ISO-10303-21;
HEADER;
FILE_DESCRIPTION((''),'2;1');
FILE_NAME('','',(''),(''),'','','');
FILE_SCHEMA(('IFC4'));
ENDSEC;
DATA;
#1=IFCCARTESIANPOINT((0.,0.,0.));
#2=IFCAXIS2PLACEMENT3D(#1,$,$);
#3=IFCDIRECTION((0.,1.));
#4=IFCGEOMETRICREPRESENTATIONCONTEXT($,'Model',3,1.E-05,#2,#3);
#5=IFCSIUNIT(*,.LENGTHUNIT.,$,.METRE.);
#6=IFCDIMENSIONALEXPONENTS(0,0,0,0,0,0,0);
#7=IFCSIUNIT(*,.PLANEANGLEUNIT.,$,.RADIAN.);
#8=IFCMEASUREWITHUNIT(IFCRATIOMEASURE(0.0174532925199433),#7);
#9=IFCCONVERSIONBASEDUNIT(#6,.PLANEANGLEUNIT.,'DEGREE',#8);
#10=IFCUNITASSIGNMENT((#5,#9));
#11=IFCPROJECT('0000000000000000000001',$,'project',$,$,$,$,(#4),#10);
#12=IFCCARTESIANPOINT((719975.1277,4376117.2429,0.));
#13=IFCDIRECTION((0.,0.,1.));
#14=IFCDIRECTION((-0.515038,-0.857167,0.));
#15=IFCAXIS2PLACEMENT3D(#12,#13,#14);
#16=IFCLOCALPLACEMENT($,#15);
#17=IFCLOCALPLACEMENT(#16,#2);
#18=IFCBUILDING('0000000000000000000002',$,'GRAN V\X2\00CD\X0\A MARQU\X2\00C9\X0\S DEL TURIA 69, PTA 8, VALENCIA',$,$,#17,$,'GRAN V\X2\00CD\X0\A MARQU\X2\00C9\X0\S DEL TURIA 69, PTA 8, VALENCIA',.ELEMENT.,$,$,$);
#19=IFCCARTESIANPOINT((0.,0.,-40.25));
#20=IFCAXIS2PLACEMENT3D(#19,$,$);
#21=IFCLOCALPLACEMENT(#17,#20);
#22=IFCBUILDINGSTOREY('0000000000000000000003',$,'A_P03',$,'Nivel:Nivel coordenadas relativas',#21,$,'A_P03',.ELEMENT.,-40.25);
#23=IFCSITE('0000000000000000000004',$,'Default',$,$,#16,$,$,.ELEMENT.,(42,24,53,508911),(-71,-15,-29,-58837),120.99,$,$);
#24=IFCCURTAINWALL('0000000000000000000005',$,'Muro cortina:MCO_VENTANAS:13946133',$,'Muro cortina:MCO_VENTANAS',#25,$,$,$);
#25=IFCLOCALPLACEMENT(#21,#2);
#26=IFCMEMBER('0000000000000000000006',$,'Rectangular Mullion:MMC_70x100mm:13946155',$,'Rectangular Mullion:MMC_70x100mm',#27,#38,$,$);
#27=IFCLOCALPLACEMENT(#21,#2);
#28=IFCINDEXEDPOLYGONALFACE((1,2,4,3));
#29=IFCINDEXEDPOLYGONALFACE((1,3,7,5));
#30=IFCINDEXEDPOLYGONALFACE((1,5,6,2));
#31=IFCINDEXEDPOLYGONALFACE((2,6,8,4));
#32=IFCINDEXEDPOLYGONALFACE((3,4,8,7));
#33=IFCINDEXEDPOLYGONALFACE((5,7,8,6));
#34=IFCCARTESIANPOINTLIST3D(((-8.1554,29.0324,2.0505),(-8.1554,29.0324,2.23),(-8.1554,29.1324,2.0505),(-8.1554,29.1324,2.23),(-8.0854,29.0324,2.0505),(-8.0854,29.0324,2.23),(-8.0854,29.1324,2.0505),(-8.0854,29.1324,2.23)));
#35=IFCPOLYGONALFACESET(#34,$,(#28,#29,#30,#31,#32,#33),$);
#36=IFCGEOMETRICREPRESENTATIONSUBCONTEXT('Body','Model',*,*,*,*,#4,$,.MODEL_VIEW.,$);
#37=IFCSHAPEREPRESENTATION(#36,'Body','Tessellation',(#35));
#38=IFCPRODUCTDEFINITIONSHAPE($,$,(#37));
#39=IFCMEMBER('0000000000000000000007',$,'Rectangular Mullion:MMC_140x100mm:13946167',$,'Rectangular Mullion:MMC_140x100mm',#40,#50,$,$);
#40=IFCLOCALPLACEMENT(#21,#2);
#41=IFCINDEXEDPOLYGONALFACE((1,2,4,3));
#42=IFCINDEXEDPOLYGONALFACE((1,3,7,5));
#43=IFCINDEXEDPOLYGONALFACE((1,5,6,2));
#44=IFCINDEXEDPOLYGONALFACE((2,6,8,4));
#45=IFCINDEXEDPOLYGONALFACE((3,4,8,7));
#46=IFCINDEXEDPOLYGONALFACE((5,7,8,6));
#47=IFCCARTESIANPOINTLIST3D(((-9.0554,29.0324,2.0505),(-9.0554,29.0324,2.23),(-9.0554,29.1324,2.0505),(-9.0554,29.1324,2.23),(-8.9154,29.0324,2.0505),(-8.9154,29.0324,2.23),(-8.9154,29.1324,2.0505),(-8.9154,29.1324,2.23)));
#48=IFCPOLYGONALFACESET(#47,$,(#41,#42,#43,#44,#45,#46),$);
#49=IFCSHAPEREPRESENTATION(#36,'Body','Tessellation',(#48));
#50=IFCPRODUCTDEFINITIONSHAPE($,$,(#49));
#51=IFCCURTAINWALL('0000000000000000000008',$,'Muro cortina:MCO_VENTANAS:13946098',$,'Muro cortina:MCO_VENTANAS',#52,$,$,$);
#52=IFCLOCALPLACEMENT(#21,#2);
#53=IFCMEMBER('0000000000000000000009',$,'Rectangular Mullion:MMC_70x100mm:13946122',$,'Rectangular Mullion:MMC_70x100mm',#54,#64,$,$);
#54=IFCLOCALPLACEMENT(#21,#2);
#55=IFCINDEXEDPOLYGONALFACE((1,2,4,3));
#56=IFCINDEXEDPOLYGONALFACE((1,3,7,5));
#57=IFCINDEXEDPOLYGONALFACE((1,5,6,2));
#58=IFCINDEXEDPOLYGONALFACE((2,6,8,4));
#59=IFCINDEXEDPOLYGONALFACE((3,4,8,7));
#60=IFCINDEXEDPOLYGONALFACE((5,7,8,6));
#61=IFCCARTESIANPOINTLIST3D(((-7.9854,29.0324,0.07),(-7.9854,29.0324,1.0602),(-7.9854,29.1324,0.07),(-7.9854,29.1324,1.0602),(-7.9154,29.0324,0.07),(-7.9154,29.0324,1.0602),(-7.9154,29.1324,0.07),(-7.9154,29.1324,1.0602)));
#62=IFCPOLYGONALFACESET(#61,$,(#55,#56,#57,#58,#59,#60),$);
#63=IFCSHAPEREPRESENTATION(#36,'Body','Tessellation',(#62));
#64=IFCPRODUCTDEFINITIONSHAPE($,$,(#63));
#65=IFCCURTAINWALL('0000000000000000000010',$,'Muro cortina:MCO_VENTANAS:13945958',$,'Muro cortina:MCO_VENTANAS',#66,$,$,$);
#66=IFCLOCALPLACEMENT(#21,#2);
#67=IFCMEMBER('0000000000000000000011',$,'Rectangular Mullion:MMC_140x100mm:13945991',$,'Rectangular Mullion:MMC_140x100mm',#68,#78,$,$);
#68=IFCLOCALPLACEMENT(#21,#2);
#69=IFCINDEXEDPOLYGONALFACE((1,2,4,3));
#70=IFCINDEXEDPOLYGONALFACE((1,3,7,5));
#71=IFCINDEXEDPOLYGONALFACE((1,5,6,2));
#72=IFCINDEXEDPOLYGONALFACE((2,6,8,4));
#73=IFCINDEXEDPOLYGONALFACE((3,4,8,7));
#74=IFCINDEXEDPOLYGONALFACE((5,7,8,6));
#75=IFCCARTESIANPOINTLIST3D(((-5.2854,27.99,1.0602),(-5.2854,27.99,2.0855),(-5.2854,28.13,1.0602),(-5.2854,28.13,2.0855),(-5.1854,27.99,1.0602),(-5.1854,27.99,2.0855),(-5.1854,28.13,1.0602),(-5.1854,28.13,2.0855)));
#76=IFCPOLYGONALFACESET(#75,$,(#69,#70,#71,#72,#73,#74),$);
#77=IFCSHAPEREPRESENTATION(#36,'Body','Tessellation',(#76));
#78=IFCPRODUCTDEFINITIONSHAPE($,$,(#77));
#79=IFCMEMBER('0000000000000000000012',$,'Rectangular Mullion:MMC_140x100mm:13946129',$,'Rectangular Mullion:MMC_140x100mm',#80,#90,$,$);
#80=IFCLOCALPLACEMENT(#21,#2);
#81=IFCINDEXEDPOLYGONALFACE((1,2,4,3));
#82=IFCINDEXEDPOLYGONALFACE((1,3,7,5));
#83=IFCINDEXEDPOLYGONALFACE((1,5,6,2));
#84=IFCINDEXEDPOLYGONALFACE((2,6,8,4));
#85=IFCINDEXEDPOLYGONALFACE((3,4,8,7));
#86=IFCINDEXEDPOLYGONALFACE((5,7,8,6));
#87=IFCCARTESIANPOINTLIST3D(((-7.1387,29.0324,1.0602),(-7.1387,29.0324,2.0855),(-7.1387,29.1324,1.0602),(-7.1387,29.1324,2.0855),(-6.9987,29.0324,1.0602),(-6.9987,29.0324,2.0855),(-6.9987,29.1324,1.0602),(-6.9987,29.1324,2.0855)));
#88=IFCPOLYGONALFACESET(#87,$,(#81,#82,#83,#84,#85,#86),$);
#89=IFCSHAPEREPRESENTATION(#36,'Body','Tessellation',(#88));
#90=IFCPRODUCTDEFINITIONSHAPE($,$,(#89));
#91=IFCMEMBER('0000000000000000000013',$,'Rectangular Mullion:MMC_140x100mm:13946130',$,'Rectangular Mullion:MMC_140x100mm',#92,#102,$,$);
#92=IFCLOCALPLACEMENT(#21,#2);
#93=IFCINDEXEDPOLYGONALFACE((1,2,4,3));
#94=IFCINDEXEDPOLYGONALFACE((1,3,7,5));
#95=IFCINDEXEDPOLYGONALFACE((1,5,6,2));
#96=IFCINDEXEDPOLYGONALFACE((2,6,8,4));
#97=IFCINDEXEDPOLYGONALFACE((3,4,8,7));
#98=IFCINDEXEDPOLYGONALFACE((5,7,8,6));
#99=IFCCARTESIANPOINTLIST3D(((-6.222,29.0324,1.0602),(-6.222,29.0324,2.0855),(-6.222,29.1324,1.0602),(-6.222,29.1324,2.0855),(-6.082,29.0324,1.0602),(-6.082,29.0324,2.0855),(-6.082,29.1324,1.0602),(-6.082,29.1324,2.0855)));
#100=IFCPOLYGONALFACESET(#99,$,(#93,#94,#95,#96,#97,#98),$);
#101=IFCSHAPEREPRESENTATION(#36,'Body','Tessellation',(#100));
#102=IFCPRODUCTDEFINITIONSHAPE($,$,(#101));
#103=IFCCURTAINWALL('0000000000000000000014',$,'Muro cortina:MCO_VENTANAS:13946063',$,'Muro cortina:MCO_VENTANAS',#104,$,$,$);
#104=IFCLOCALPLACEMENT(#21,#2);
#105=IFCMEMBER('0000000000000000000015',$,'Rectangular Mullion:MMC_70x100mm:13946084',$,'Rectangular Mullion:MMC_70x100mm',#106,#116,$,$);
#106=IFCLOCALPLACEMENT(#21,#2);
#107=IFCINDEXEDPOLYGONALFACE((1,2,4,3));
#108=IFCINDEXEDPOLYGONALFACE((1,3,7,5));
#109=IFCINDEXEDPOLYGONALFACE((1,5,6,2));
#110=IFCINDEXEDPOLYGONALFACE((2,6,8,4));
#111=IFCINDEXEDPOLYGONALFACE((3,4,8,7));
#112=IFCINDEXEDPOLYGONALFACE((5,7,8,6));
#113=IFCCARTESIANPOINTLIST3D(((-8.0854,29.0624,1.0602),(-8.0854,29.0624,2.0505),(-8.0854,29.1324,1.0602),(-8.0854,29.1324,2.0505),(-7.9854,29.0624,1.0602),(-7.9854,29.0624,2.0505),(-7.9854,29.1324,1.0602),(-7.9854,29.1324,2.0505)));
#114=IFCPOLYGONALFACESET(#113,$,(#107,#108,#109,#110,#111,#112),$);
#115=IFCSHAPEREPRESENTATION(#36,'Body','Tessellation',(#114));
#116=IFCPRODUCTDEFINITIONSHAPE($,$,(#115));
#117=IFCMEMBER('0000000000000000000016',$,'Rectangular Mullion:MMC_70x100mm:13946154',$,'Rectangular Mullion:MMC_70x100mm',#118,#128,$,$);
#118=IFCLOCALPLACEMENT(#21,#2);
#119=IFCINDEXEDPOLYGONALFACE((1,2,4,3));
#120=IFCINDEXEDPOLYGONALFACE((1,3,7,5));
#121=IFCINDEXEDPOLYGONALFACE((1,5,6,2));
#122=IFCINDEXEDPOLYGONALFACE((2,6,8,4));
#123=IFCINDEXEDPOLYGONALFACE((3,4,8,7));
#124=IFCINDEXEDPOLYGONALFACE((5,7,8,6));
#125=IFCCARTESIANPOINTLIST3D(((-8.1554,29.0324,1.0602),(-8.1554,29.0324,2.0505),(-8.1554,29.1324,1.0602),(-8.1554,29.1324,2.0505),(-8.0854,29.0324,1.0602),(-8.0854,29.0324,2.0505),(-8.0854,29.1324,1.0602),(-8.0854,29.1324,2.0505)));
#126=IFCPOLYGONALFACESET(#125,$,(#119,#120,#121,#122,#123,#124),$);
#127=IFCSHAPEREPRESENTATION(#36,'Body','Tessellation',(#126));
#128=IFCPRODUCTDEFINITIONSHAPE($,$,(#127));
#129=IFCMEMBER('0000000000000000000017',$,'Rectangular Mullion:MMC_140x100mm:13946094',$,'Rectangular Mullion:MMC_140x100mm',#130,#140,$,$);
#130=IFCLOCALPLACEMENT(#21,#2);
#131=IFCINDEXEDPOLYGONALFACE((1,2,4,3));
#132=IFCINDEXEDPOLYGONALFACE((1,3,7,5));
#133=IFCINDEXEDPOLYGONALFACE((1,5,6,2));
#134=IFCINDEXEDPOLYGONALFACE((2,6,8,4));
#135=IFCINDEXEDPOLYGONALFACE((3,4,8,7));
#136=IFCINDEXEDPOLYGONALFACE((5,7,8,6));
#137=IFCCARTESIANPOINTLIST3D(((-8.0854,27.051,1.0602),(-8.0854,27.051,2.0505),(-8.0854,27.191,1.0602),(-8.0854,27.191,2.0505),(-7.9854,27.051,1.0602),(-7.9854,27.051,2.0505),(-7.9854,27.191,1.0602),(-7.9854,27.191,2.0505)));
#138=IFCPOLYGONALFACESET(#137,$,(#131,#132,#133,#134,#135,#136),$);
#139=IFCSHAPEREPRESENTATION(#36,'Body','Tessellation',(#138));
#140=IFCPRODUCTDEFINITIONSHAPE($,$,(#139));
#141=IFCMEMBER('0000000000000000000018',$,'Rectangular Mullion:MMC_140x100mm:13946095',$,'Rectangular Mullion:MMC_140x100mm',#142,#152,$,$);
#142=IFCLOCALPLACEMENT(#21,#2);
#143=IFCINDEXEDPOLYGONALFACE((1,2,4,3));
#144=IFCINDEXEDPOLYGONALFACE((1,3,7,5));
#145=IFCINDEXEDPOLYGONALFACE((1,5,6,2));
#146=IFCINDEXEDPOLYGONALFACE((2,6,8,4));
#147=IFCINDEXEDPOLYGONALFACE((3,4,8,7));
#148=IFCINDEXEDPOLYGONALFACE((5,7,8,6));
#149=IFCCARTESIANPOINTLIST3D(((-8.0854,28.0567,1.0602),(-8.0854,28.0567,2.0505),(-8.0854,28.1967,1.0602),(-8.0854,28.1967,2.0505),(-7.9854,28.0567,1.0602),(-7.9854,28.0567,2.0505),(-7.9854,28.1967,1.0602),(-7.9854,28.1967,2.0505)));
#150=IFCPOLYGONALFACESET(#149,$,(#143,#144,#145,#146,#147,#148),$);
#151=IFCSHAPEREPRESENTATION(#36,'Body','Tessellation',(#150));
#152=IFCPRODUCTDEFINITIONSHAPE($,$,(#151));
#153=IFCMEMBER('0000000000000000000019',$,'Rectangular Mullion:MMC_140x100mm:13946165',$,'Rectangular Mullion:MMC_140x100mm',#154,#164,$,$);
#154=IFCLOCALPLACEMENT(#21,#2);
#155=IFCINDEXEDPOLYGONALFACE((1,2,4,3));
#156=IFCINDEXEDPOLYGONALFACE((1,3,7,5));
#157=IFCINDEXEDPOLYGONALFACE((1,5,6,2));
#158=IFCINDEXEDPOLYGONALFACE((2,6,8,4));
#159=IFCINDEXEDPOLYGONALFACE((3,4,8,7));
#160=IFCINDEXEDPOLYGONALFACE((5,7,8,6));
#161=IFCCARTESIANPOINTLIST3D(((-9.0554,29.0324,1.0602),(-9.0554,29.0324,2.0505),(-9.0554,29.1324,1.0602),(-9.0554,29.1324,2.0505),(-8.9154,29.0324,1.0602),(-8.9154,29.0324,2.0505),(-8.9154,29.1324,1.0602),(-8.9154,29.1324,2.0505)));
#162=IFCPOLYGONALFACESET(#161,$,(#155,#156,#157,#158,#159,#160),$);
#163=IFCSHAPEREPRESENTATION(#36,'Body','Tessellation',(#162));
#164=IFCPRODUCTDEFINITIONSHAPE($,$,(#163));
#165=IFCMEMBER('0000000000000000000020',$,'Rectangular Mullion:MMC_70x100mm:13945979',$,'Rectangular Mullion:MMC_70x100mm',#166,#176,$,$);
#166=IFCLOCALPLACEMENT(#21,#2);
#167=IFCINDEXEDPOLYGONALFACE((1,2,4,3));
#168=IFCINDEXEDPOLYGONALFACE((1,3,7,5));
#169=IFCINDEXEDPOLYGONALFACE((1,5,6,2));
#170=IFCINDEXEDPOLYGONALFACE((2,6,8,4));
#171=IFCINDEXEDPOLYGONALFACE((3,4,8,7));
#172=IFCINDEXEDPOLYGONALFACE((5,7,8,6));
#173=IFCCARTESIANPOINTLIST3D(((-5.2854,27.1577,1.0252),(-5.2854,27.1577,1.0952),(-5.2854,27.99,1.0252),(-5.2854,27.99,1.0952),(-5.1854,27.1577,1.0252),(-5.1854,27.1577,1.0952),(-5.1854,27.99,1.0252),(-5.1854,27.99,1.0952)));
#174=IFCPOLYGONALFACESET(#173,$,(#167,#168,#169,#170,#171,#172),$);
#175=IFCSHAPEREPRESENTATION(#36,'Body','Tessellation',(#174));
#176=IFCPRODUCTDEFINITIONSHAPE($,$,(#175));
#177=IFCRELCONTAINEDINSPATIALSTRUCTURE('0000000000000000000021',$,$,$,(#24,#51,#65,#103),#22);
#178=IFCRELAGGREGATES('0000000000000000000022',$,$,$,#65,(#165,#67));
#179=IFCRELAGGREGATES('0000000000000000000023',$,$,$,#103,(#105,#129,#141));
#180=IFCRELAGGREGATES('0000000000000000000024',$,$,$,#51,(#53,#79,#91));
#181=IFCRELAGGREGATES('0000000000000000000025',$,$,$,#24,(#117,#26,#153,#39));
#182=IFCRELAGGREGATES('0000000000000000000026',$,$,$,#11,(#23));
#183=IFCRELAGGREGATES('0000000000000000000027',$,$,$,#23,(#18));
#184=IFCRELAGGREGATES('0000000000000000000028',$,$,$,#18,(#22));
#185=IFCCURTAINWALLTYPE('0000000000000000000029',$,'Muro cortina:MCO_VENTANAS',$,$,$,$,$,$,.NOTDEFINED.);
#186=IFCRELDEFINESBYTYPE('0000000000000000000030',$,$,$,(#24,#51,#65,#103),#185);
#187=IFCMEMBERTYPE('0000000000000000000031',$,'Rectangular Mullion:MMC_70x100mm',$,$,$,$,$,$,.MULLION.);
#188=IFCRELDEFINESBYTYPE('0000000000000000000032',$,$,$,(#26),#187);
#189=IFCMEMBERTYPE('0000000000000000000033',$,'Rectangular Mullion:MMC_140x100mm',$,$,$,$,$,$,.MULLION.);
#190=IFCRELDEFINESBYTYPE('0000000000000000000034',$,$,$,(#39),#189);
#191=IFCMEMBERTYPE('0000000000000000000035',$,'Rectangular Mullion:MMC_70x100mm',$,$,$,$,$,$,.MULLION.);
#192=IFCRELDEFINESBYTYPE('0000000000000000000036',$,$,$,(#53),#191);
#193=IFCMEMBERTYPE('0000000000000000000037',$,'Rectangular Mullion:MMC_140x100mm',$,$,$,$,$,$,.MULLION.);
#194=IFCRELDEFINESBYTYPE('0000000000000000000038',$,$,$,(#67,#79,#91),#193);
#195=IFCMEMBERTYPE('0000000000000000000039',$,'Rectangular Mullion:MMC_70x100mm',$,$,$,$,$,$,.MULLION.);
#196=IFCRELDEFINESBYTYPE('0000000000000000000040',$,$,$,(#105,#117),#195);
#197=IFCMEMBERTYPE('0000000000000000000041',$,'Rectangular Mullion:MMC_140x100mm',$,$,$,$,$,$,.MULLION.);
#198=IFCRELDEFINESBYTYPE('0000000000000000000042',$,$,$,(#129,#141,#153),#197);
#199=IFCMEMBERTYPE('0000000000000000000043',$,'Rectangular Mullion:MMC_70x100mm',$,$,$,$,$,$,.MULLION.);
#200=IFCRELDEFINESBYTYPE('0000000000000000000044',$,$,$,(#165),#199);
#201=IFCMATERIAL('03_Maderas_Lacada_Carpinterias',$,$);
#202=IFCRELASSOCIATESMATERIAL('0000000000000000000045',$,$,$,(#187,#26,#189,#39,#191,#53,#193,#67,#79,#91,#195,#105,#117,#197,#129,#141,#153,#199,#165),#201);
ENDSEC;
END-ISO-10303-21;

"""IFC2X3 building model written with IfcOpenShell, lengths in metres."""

from ifc_helpers import new_model, entity, si_unit, converted_unit, direction, frame, origin, origin_2d_with_axis, place, context, subcontext, project, spatial, rectangle, extrude, source, transform, mapped, material, type_object, type_shapes, element, aggregate, save


model = new_model("IFC2X3")

# Units and contexts
model_context = context("Model", 3, precision=1e-05, world=origin(), true_north=direction((0.0, 1.0)))
body_context = subcontext(model_context, "Body", "Model", "MODEL_VIEW")
ifc_project = project(units=[si_unit("LENGTHUNIT", "METRE"), converted_unit("PLANEANGLEUNIT", "DEGREE", entity("IfcRatioMeasure", 0.0174532925199433), si_unit("PLANEANGLEUNIT", "RADIAN"), dimensions=[0, 0, 0, 0, 0, 0, 0])], contexts=[model_context])

# Site, building, storey
site_placement = place(None, frame((719975.1277, 4376117.2429, 0.0), z_axis=(0.0, 0.0, 1.0), x_axis=(-0.515038, -0.857167, 0.0)))
site = spatial("IfcSite", under=ifc_project, at=site_placement, Name="Default", CompositionType="ELEMENT", RefLatitude=(42, 24, 53, 508911), RefLongitude=(-71, -15, -29, -58837), RefElevation=120.99)
building_placement = place(site_placement, origin())
building = spatial("IfcBuilding", under=site, at=building_placement, Name="GRAN VÍA MARQUÉS DEL TURIA 69, PTA 8, VALENCIA", LongName="GRAN VÍA MARQUÉS DEL TURIA 69, PTA 8, VALENCIA", CompositionType="ELEMENT")
storey_placement = place(building_placement, frame((0.0, 0.0, -40.25)))
storey = spatial("IfcBuildingStorey", under=building, at=storey_placement, Name="A_P03", ObjectType="Nivel:Nivel coordenadas relativas", LongName="A_P03", CompositionType="ELEMENT", Elevation=-40.25)

# Curtain wall, members
curtain_wall_type = type_object("IfcCurtainWallType", Name="Muro cortina:MCO_VENTANAS", PredefinedType="NOTDEFINED")
curtain_wall_1_placement = place(storey_placement, frame((0.0, 0.0, 40.25)))
curtain_wall_1 = element("IfcCurtainWall", 1, at=curtain_wall_1_placement, inside=storey, type_object=curtain_wall_type, Name="Muro cortina:MCO_VENTANAS:13946133", ObjectType="Muro cortina:MCO_VENTANAS")
ifc_material_1 = material(Name="03_Maderas_Lacada_Carpinterias")
member_type_1 = type_object("IfcMemberType", Name="Rectangular Mullion:MMC_70x100mm", PredefinedType="MULLION", material=ifc_material_1)
shared_shape_1 = source(origin(), body_context, "Body", "SweptSolid", [
    extrude(rectangle(XDim=0.1, YDim=0.07, at=origin_2d_with_axis()), frame((-0.035, 0.0, -0.1795), z_axis=(0.0, 0.0, 1.0), x_axis=(0.0, -1.0, 0.0)), (0.0, 0.0, 1.0), 0.1795),
])
type_shapes(member_type_1, [shared_shape_1])
member_1_placement = place(storey_placement, frame((-8.0854, 29.0824, 2.0505), z_axis=(0.0, 0.0, -1.0), x_axis=(1.0, 0.0, 0.0)))
member_1 = element("IfcMember", 2, at=member_1_placement, type_object=member_type_1, material=ifc_material_1, Name="Rectangular Mullion:MMC_70x100mm:13946155", ObjectType="Rectangular Mullion:MMC_70x100mm", context=body_context, shape_type="MappedRepresentation", body=[
    mapped(shared_shape_1, transform((0.0, 0.0, 0.0), scale=1.0)),
])
member_type_2 = type_object("IfcMemberType", Name="Rectangular Mullion:MMC_140x100mm", PredefinedType="MULLION", material=ifc_material_1)
shared_shape_2 = source(origin(), body_context, "Body", "SweptSolid", [
    extrude(rectangle(XDim=0.1, YDim=0.14, at=origin_2d_with_axis()), frame((0.0, 0.0, -0.1795), z_axis=(0.0, 0.0, 1.0), x_axis=(0.0, -1.0, 0.0)), (0.0, 0.0, 1.0), 0.1795),
])
type_shapes(member_type_2, [shared_shape_2])
member_2_placement = place(storey_placement, frame((-8.9854, 29.0824, 2.0505), z_axis=(0.0, 0.0, -1.0), x_axis=(1.0, 0.0, 0.0)))
member_2 = element("IfcMember", 3, at=member_2_placement, type_object=member_type_2, material=ifc_material_1, Name="Rectangular Mullion:MMC_140x100mm:13946167", ObjectType="Rectangular Mullion:MMC_140x100mm", context=body_context, shape_type="MappedRepresentation", body=[
    mapped(shared_shape_2, transform((0.0, 0.0, 0.0), scale=1.0)),
])

# Curtain walls, members
curtain_wall_2_placement = place(storey_placement, frame((0.0, 0.0, 40.25)))
curtain_wall_2 = element("IfcCurtainWall", 4, at=curtain_wall_2_placement, inside=storey, type_object=curtain_wall_type, Name="Muro cortina:MCO_VENTANAS:13946098", ObjectType="Muro cortina:MCO_VENTANAS")
member_type_3 = type_object("IfcMemberType", Name="Rectangular Mullion:MMC_70x100mm", PredefinedType="MULLION", material=ifc_material_1)
shared_shape_3 = source(origin(), body_context, "Body", "SweptSolid", [
    extrude(rectangle(XDim=0.1, YDim=0.07, at=origin_2d_with_axis()), frame((-0.035, 0.0, -0.9902), z_axis=(0.0, 0.0, 1.0), x_axis=(0.0, -1.0, 0.0)), (0.0, 0.0, 1.0), 0.9902),
])
type_shapes(member_type_3, [shared_shape_3])
member_3_placement = place(storey_placement, frame((-7.9854, 29.0824, 1.0602), z_axis=(0.0, 0.0, 1.0), x_axis=(-1.0, 0.0, 0.0)))
member_3 = element("IfcMember", 5, at=member_3_placement, type_object=member_type_3, material=ifc_material_1, Name="Rectangular Mullion:MMC_70x100mm:13946122", ObjectType="Rectangular Mullion:MMC_70x100mm", context=body_context, shape_type="MappedRepresentation", body=[
    mapped(shared_shape_3, transform((0.0, 0.0, 0.0), scale=1.0)),
])
curtain_wall_3_placement = place(storey_placement, frame((0.0, 0.0, 40.25)))
curtain_wall_3 = element("IfcCurtainWall", 6, at=curtain_wall_3_placement, inside=storey, type_object=curtain_wall_type, Name="Muro cortina:MCO_VENTANAS:13945958", ObjectType="Muro cortina:MCO_VENTANAS")
member_type_4 = type_object("IfcMemberType", Name="Rectangular Mullion:MMC_140x100mm", PredefinedType="MULLION", material=ifc_material_1)
shared_shape_4 = source(origin(), body_context, "Body", "SweptSolid", [
    extrude(rectangle(XDim=0.1, YDim=0.14, at=origin_2d_with_axis()), frame((0.0, 0.0, -1.0252), z_axis=(0.0, 0.0, 1.0), x_axis=(0.0, -1.0, 0.0)), (0.0, 0.0, 1.0), 1.0252),
])
type_shapes(member_type_4, [shared_shape_4])
member_4_placement = place(storey_placement, frame((-5.2354, 28.06, 1.0602), z_axis=(0.0, 0.0, -1.0), x_axis=(0.0, 1.0, 0.0)))
member_4 = element("IfcMember", 7, at=member_4_placement, type_object=member_type_4, material=ifc_material_1, Name="Rectangular Mullion:MMC_140x100mm:13945991", ObjectType="Rectangular Mullion:MMC_140x100mm", context=body_context, shape_type="MappedRepresentation", body=[
    mapped(shared_shape_4, transform((0.0, 0.0, 0.0), scale=1.0)),
])

# Members
member_5_placement = place(storey_placement, frame((-7.0687, 29.0824, 1.0602), z_axis=(0.0, 0.0, -1.0), x_axis=(1.0, 0.0, 0.0)))
member_5 = element("IfcMember", 8, at=member_5_placement, type_object=member_type_4, material=ifc_material_1, Name="Rectangular Mullion:MMC_140x100mm:13946129", ObjectType="Rectangular Mullion:MMC_140x100mm", context=body_context, shape_type="MappedRepresentation", body=[
    mapped(shared_shape_4, transform((0.0, 0.0, 0.0), scale=1.0)),
])
member_6_placement = place(storey_placement, frame((-6.152, 29.0824, 1.0602), z_axis=(0.0, 0.0, -1.0), x_axis=(1.0, 0.0, 0.0)))
member_6 = element("IfcMember", 9, at=member_6_placement, type_object=member_type_4, material=ifc_material_1, Name="Rectangular Mullion:MMC_140x100mm:13946130", ObjectType="Rectangular Mullion:MMC_140x100mm", context=body_context, shape_type="MappedRepresentation", body=[
    mapped(shared_shape_4, transform((0.0, 0.0, 0.0), scale=1.0)),
])

# Curtain wall, member
curtain_wall_4_placement = place(storey_placement, frame((0.0, 0.0, 40.25)))
curtain_wall_4 = element("IfcCurtainWall", 10, at=curtain_wall_4_placement, inside=storey, type_object=curtain_wall_type, Name="Muro cortina:MCO_VENTANAS:13946063", ObjectType="Muro cortina:MCO_VENTANAS")
member_type_5 = type_object("IfcMemberType", Name="Rectangular Mullion:MMC_70x100mm", PredefinedType="MULLION", material=ifc_material_1)
shared_shape_5 = source(origin(), body_context, "Body", "SweptSolid", [
    extrude(rectangle(XDim=0.1, YDim=0.07, at=origin_2d_with_axis()), frame((-0.035, 0.0, -0.9902), z_axis=(0.0, 0.0, 1.0), x_axis=(0.0, -1.0, 0.0)), (0.0, 0.0, 1.0), 0.9902),
])
type_shapes(member_type_5, [shared_shape_5])
member_7_placement = place(storey_placement, frame((-8.0354, 29.1324, 1.0602), z_axis=(0.0, 0.0, -1.0), x_axis=(0.0, 1.0, 0.0)))
member_7 = element("IfcMember", 11, at=member_7_placement, type_object=member_type_5, material=ifc_material_1, Name="Rectangular Mullion:MMC_70x100mm:13946084", ObjectType="Rectangular Mullion:MMC_70x100mm", context=body_context, shape_type="MappedRepresentation", body=[
    mapped(shared_shape_5, transform((0.0, 0.0, 0.0), scale=1.0)),
])

# Members
member_8_placement = place(storey_placement, frame((-8.0854, 29.0824, 1.0602), z_axis=(0.0, 0.0, -1.0), x_axis=(1.0, 0.0, 0.0)))
member_8 = element("IfcMember", 12, at=member_8_placement, type_object=member_type_5, material=ifc_material_1, Name="Rectangular Mullion:MMC_70x100mm:13946154", ObjectType="Rectangular Mullion:MMC_70x100mm", context=body_context, shape_type="MappedRepresentation", body=[
    mapped(shared_shape_5, transform((0.0, 0.0, 0.0), scale=1.0)),
])
member_type_6 = type_object("IfcMemberType", Name="Rectangular Mullion:MMC_140x100mm", PredefinedType="MULLION", material=ifc_material_1)
shared_shape_6 = source(origin(), body_context, "Body", "SweptSolid", [
    extrude(rectangle(XDim=0.1, YDim=0.14, at=origin_2d_with_axis()), frame((0.0, 0.0, -0.9902), z_axis=(0.0, 0.0, 1.0), x_axis=(0.0, -1.0, 0.0)), (0.0, 0.0, 1.0), 0.9902),
])
type_shapes(member_type_6, [shared_shape_6])
member_9_placement = place(storey_placement, frame((-8.0354, 27.121, 1.0602), z_axis=(0.0, 0.0, -1.0), x_axis=(0.0, 1.0, 0.0)))
member_9 = element("IfcMember", 13, at=member_9_placement, type_object=member_type_6, material=ifc_material_1, Name="Rectangular Mullion:MMC_140x100mm:13946094", ObjectType="Rectangular Mullion:MMC_140x100mm", context=body_context, shape_type="MappedRepresentation", body=[
    mapped(shared_shape_6, transform((0.0, 0.0, 0.0), scale=1.0)),
])
member_10_placement = place(storey_placement, frame((-8.0354, 28.1267, 1.0602), z_axis=(0.0, 0.0, -1.0), x_axis=(0.0, 1.0, 0.0)))
member_10 = element("IfcMember", 14, at=member_10_placement, type_object=member_type_6, material=ifc_material_1, Name="Rectangular Mullion:MMC_140x100mm:13946095", ObjectType="Rectangular Mullion:MMC_140x100mm", context=body_context, shape_type="MappedRepresentation", body=[
    mapped(shared_shape_6, transform((0.0, 0.0, 0.0), scale=1.0)),
])
member_11_placement = place(storey_placement, frame((-8.9854, 29.0824, 1.0602), z_axis=(0.0, 0.0, -1.0), x_axis=(1.0, 0.0, 0.0)))
member_11 = element("IfcMember", 15, at=member_11_placement, type_object=member_type_6, material=ifc_material_1, Name="Rectangular Mullion:MMC_140x100mm:13946165", ObjectType="Rectangular Mullion:MMC_140x100mm", context=body_context, shape_type="MappedRepresentation", body=[
    mapped(shared_shape_6, transform((0.0, 0.0, 0.0), scale=1.0)),
])
member_type_7 = type_object("IfcMemberType", Name="Rectangular Mullion:MMC_70x100mm", PredefinedType="MULLION", material=ifc_material_1)
shared_shape_7 = source(origin(), body_context, "Body", "SweptSolid", [
    extrude(rectangle(XDim=0.1, YDim=0.07, at=origin_2d_with_axis()), frame((0.0, 0.0, -0.8323), z_axis=(0.0, 0.0, 1.0), x_axis=(0.0, -1.0, 0.0)), (0.0, 0.0, 1.0), 0.8323),
])
type_shapes(member_type_7, [shared_shape_7])
member_12_placement = place(storey_placement, frame((-5.2354, 27.99, 1.0602), z_axis=(0.0, 1.0, 0.0), x_axis=(0.0, 0.0, 1.0)))
member_12 = element("IfcMember", 16, at=member_12_placement, type_object=member_type_7, material=ifc_material_1, Name="Rectangular Mullion:MMC_70x100mm:13945979", ObjectType="Rectangular Mullion:MMC_70x100mm", context=body_context, shape_type="MappedRepresentation", body=[
    mapped(shared_shape_7, transform((0.0, 0.0, 0.0), scale=1.0)),
])

aggregate(curtain_wall_3, [member_12, member_4])
aggregate(curtain_wall_4, [member_7, member_9, member_10])
aggregate(curtain_wall_2, [member_3, member_5, member_6])
aggregate(curtain_wall_1, [member_8, member_1, member_11, member_2])

save(model, "model.ifc")
